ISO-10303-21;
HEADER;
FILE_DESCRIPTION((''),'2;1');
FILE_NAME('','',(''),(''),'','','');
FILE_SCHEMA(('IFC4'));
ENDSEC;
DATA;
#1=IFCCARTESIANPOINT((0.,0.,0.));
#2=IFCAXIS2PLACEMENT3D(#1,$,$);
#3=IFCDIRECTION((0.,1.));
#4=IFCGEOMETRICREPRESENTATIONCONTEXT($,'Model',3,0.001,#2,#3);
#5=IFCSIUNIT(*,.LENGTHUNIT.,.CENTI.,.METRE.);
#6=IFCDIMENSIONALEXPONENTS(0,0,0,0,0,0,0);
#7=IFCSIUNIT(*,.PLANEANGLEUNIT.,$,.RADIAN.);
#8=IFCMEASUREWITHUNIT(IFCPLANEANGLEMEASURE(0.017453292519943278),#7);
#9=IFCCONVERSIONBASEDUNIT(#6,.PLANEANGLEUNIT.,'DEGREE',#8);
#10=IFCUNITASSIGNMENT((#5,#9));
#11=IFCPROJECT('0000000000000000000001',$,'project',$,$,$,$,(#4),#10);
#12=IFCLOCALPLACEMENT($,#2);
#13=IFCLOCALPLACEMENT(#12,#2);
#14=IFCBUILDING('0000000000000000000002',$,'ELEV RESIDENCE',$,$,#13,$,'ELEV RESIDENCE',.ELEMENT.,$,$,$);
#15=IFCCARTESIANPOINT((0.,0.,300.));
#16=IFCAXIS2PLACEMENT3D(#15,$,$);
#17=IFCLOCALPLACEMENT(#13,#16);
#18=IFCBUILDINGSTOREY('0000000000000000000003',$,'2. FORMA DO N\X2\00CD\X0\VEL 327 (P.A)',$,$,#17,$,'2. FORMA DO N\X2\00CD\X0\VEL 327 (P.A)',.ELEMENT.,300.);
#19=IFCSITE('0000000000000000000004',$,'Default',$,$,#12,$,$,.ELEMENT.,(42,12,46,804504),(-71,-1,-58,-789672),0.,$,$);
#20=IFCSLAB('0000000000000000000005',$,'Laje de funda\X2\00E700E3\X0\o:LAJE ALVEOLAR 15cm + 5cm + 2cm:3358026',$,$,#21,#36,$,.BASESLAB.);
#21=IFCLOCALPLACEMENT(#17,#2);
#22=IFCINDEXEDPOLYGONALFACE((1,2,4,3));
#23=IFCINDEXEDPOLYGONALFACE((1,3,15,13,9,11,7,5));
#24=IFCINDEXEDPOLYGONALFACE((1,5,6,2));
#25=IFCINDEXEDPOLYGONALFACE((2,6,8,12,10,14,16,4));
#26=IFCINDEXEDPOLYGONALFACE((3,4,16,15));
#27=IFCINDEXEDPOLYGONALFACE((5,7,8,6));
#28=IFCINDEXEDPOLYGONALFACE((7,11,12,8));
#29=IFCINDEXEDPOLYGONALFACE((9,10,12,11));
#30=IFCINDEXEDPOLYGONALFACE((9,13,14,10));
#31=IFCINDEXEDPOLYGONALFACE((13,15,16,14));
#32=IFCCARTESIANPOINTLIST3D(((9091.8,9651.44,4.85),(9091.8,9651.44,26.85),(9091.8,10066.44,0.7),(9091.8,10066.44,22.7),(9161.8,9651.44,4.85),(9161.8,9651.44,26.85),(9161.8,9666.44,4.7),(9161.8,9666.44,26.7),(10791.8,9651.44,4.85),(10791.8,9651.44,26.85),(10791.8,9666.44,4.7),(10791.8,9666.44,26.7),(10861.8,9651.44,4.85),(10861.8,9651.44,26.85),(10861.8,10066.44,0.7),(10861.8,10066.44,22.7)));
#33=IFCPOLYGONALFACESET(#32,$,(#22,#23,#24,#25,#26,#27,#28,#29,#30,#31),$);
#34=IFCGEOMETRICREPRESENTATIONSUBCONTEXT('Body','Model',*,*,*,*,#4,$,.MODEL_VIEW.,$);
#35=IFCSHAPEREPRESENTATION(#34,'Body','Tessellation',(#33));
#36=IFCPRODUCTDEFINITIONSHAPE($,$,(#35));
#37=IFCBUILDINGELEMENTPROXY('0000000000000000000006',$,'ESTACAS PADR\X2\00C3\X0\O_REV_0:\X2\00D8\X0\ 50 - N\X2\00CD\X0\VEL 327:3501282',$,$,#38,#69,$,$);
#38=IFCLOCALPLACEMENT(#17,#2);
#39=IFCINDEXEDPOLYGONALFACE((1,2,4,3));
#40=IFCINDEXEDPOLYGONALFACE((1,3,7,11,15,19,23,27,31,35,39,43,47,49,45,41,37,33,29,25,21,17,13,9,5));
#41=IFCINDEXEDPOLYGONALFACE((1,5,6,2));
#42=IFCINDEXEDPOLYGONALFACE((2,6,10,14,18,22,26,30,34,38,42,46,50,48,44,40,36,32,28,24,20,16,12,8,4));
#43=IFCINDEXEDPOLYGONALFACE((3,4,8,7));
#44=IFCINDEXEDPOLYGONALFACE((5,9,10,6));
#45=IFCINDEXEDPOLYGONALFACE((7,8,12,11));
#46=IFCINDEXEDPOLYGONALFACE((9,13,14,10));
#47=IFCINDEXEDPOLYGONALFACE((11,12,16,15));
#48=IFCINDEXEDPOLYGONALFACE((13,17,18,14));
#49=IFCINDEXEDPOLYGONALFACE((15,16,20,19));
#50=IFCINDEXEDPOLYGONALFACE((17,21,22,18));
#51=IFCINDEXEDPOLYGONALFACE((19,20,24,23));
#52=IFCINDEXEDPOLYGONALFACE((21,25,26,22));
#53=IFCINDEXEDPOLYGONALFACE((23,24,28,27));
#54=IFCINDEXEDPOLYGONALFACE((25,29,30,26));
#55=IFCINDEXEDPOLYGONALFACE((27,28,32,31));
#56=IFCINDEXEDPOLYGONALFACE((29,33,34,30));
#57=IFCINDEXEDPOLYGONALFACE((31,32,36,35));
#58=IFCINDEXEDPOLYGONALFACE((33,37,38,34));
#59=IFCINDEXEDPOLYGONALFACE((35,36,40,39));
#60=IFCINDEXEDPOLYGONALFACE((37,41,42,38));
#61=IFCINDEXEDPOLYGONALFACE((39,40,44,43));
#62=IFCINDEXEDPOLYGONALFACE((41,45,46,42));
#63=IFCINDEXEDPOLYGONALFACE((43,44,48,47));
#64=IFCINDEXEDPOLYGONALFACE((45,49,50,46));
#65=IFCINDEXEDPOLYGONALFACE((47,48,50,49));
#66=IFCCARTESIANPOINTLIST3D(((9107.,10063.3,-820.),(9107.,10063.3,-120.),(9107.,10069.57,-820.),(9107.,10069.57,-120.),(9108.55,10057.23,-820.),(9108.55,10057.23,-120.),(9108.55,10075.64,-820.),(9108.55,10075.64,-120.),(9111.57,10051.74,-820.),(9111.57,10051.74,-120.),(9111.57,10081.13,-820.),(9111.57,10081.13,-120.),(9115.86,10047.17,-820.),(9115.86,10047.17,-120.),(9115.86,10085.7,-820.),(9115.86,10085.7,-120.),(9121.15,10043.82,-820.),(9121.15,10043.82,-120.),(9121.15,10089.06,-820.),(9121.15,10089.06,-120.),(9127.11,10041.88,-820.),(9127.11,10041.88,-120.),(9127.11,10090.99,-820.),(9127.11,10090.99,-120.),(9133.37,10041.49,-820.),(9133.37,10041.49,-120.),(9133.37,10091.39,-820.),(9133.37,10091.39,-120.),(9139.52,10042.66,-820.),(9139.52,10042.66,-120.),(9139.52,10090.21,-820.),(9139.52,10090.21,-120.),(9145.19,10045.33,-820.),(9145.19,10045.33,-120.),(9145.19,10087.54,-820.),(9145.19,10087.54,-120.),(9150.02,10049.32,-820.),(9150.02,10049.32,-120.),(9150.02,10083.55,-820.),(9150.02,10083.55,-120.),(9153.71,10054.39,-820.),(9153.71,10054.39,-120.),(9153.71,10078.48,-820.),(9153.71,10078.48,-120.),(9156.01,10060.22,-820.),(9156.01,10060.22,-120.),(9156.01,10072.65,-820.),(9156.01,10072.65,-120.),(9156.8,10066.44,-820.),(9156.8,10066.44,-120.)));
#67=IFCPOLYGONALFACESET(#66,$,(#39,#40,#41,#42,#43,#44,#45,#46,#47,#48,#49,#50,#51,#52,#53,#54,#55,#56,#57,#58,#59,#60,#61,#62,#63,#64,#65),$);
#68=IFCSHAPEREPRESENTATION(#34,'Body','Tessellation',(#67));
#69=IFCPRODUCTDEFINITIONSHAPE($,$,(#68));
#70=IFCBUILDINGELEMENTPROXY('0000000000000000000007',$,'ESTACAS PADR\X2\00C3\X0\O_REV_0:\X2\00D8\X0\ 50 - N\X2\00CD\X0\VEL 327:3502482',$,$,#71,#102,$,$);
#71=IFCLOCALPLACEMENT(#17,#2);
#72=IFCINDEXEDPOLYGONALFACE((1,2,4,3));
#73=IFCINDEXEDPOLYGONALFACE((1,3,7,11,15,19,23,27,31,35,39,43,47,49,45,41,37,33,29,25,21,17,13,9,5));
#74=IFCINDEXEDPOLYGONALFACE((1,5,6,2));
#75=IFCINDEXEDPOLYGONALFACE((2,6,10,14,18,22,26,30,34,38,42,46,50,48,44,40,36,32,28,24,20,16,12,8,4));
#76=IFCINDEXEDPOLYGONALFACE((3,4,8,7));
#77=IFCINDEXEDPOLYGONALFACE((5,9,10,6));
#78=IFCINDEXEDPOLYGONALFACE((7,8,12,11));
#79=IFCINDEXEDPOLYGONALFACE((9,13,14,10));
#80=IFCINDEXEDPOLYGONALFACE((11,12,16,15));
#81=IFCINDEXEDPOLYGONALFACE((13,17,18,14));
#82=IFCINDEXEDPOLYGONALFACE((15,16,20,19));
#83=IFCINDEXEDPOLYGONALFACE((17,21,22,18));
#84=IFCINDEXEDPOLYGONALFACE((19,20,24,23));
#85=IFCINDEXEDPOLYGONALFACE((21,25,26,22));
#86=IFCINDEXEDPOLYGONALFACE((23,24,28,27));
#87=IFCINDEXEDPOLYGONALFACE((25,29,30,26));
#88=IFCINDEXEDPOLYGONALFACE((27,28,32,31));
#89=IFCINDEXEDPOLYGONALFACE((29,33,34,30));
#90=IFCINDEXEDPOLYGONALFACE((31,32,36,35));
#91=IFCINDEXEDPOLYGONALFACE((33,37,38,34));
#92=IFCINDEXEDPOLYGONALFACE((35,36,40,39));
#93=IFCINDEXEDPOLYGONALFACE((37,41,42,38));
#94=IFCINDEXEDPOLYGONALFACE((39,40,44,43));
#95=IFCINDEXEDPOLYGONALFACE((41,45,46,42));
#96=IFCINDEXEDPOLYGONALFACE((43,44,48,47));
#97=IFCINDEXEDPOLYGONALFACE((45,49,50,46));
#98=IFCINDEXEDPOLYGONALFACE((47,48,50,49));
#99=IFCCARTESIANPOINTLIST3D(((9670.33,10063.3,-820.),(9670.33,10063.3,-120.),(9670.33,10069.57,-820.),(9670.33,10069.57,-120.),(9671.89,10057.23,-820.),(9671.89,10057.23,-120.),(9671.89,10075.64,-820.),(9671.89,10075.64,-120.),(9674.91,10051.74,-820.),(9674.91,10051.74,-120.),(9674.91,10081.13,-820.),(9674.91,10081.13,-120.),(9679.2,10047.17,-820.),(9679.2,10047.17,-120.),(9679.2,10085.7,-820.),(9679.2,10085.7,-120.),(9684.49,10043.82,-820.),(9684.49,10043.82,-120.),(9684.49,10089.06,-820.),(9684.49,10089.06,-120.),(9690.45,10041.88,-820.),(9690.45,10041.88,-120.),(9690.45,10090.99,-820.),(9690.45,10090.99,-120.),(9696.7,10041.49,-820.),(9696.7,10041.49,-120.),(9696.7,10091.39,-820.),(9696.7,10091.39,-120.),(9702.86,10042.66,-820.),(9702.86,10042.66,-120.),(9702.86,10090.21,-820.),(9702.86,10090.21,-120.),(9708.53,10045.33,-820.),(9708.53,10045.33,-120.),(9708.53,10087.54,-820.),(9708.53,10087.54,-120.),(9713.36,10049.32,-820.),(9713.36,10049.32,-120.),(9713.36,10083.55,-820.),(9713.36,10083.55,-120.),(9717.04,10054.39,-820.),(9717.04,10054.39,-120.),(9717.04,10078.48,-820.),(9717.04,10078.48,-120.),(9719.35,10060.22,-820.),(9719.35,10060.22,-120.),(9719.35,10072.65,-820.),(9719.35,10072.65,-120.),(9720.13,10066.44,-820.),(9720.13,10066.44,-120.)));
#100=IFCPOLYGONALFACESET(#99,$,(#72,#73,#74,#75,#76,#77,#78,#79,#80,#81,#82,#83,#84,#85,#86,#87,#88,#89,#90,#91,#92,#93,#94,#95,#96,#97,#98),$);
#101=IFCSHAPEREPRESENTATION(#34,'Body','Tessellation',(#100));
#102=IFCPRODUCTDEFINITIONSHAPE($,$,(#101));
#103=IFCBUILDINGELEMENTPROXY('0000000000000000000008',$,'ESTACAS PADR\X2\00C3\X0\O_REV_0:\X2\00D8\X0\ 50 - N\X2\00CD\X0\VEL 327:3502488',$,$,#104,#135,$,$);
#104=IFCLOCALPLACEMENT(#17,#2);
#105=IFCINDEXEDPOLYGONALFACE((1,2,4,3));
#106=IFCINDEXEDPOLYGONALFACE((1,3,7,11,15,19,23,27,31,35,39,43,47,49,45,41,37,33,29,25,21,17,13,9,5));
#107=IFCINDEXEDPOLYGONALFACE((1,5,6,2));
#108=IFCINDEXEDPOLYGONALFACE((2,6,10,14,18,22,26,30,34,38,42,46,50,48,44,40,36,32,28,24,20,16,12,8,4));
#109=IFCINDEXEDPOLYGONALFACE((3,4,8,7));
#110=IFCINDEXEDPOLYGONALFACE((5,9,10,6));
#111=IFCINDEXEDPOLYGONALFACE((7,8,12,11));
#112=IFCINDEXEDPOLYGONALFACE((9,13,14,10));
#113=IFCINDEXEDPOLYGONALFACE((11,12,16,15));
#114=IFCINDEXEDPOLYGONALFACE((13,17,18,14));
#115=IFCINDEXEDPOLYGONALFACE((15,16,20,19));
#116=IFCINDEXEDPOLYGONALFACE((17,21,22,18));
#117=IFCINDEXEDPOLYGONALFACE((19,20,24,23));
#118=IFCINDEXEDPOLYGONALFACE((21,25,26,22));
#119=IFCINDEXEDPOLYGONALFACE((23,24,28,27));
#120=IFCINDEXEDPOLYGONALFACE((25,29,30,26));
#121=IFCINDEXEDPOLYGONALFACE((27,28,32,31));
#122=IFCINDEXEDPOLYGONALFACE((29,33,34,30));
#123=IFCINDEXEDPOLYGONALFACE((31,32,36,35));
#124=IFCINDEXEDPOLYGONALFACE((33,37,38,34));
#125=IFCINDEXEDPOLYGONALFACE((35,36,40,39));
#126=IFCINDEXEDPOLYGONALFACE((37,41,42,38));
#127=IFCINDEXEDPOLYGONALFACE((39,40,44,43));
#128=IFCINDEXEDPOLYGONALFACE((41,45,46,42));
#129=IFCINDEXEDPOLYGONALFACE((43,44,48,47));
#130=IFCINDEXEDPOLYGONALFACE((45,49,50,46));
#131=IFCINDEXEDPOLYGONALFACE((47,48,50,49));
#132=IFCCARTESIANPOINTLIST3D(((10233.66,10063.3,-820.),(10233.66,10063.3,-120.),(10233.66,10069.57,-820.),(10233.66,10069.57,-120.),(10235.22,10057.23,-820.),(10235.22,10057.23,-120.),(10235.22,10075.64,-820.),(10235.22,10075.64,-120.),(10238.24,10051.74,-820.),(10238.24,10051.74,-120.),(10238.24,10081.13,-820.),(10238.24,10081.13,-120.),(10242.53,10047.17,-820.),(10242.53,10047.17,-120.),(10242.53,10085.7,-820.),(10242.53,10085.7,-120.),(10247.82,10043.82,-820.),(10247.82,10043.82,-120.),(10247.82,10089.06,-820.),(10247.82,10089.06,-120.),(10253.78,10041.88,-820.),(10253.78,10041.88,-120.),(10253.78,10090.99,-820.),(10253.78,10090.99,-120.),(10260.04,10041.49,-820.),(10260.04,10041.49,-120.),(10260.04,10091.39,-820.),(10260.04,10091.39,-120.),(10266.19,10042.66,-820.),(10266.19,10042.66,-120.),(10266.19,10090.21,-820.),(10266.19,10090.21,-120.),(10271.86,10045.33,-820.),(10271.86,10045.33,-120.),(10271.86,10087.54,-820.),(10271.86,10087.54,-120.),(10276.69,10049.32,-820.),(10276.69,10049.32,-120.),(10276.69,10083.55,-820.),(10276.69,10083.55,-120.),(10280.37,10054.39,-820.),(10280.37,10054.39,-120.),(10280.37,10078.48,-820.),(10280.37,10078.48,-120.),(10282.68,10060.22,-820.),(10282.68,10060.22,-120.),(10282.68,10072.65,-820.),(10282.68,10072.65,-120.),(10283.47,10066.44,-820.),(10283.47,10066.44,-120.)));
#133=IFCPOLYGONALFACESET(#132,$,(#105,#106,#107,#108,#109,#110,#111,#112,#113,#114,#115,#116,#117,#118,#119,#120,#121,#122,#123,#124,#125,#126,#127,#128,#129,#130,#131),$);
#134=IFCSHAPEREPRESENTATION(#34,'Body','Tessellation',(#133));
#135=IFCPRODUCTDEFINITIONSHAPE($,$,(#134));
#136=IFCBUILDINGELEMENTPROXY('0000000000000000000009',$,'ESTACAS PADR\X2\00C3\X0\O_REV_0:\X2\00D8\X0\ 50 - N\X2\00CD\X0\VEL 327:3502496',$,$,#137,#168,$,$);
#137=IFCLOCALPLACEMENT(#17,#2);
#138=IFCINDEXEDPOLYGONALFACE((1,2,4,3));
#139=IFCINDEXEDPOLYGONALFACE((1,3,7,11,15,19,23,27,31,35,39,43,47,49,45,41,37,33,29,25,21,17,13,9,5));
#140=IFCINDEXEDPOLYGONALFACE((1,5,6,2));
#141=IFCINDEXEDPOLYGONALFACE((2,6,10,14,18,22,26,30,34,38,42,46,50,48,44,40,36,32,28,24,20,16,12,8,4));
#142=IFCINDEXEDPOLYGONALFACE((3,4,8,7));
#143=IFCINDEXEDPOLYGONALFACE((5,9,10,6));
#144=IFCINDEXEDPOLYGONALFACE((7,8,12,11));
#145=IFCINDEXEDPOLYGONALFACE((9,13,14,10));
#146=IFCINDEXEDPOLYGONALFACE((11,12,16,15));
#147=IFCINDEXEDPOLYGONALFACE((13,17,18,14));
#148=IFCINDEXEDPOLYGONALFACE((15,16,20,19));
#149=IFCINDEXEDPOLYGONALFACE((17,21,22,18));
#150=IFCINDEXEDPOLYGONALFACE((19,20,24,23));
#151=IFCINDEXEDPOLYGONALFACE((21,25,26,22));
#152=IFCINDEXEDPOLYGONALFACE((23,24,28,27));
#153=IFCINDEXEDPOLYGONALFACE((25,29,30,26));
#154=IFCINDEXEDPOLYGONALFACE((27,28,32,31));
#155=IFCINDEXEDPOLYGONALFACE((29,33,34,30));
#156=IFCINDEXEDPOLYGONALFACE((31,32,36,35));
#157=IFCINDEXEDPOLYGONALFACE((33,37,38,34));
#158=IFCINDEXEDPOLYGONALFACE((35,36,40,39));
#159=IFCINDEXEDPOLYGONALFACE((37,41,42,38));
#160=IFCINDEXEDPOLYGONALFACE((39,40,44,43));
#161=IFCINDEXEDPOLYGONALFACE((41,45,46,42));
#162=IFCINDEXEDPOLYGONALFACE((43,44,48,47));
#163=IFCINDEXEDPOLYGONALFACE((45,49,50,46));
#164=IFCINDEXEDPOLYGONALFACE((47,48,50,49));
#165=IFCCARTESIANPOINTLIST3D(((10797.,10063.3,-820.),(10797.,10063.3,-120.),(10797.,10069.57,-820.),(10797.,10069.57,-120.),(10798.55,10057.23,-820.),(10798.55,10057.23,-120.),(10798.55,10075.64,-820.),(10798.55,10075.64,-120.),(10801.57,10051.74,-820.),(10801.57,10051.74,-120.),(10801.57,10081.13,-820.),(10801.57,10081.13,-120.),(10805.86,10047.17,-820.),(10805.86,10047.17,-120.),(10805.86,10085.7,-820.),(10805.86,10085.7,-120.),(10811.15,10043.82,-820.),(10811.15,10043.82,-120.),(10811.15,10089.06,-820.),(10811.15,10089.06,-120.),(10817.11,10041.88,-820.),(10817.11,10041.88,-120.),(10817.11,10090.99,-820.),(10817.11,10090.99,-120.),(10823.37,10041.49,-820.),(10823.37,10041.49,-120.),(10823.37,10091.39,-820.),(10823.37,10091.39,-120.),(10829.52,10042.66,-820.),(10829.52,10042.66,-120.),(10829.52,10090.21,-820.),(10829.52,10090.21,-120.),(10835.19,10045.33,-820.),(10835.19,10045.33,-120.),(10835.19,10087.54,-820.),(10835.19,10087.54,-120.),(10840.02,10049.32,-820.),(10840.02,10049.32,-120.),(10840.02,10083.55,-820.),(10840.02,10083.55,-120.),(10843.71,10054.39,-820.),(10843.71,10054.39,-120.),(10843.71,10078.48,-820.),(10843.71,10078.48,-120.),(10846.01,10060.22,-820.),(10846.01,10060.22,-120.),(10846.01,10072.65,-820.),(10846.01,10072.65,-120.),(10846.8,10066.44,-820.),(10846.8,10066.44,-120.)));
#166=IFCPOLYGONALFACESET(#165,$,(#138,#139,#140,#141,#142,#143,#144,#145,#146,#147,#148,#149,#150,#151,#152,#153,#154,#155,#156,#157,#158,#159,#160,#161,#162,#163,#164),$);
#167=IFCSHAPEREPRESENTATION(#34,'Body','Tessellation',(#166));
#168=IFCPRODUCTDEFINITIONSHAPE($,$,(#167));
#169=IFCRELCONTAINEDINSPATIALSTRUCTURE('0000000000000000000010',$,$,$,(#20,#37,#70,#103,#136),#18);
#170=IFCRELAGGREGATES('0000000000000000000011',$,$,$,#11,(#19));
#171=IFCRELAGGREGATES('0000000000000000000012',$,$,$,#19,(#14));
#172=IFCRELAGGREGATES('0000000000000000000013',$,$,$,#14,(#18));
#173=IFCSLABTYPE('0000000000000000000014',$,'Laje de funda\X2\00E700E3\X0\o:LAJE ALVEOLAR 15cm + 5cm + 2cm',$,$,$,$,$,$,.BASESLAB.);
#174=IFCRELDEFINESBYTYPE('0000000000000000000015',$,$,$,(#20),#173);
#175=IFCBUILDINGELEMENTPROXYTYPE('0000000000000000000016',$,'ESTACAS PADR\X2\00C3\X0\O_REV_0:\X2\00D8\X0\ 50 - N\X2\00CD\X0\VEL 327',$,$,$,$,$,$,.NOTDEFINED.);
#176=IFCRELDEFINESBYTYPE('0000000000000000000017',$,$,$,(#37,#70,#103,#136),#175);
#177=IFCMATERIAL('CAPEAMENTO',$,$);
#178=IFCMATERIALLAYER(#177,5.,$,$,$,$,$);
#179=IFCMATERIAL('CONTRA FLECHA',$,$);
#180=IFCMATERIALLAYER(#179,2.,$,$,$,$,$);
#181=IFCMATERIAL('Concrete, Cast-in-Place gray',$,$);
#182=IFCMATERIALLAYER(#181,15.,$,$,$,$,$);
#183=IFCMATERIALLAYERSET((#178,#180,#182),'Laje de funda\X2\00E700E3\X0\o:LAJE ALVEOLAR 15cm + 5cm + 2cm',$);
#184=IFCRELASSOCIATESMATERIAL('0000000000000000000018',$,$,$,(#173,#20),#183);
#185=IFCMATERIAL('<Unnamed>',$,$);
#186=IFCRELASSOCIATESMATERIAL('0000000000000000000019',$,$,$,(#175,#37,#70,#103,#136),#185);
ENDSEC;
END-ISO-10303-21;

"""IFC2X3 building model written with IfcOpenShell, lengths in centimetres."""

from ifc_helpers import new_model, entity, si_unit, converted_unit, direction, frame, frame_2d, origin, place, context, subcontext, project, spatial, polyline, circle, outline, extrude, clip, halfspace, source, transform, mapped, material, layer, layer_set, layer_usage, type_object, type_shapes, element, save


model = new_model("IFC2X3")

# Units and contexts
model_context = context("Model", 3, precision=0.001, world=origin(), true_north=direction((0.0, 1.0)))
body_context = subcontext(model_context, "Body", "Model", "MODEL_VIEW")
ifc_project = project(units=[si_unit("LENGTHUNIT", "METRE", prefix="CENTI"), converted_unit("PLANEANGLEUNIT", "DEGREE", entity("IfcPlaneAngleMeasure", 0.017453292519943278), si_unit("PLANEANGLEUNIT", "RADIAN"), dimensions=[0, 0, 0, 0, 0, 0, 0])], contexts=[model_context])

# Site, building, storey
site_placement = place(None, origin())
site = spatial("IfcSite", under=ifc_project, at=site_placement, Name="Default", CompositionType="ELEMENT", RefLatitude=(42, 12, 46, 804504), RefLongitude=(-71, -1, -58, -789672), RefElevation=0.0)
building_placement = place(site_placement, origin())
building = spatial("IfcBuilding", under=site, at=building_placement, Name="ELEV RESIDENCE", LongName="ELEV RESIDENCE", CompositionType="ELEMENT")
storey_placement = place(building_placement, frame((0.0, 0.0, 300.0)))
storey = spatial("IfcBuildingStorey", under=building, at=storey_placement, Name="2. FORMA DO NÍVEL 327 (P.A)", LongName="2. FORMA DO NÍVEL 327 (P.A)", CompositionType="ELEMENT", Elevation=300.0)

# Shared definitions
ifc_material_1 = material(Name="CAPEAMENTO")
ifc_material_2 = material(Name="CONTRA FLECHA")
ifc_material_3 = material(Name="Concrete, Cast-in-Place gray")

# Slab
ifc_layer_1 = layer(ifc_material_1, 5.0)
ifc_layer_2 = layer(ifc_material_2, 2.0)
ifc_layer_3 = layer(ifc_material_3, 15.0)
ifc_layer_set_1 = layer_set([ifc_layer_1, ifc_layer_2, ifc_layer_3], Name="Laje de fundação:LAJE ALVEOLAR 15cm + 5cm + 2cm")
ifc_layer_usage_1 = layer_usage(ifc_layer_set_1, "AXIS3", "POSITIVE", 0.0)
slab_type_1 = type_object("IfcSlabType", Name="Laje de fundação:LAJE ALVEOLAR 15cm + 5cm + 2cm", PredefinedType="BASESLAB", material=ifc_layer_set_1)
slab_1_placement = place(storey_placement, origin())
element("IfcSlab", 1, at=slab_1_placement, inside=storey, type_object=slab_type_1, material=ifc_layer_usage_1, Name="Laje de fundação:LAJE ALVEOLAR 15cm + 5cm + 2cm:3358026", PredefinedType="BASESLAB", context=body_context, shape_type="Clipping", body=[
    clip(clip(extrude(outline(polyline([(-107.51, -885.0), (307.52, -885.0), (307.52, 885.0), (-107.51, 885.0), (-107.51, 815.0), (-92.5, 815.0), (-92.5, -815.0), (-107.51, -815.0), (-107.51, -885.0)])), frame((9976.8, 9758.94, 25.77), z_axis=(0.0, -0.01, -0.99995), x_axis=(0.0, 0.99995, -0.01)), (0.01, 0.0, 0.99995), 22.0), halfspace(frame((9976.8, 9666.44, 4.7), z_axis=(0.0, -0.01, -0.99995), x_axis=(0.0, 0.99995, -0.01)), False)), halfspace(frame((9976.8, 9666.44, 26.7), z_axis=(0.0, 0.01, 0.99995), x_axis=(0.0, -0.99995, 0.01)), False)),
])

# Building element proxies
ifc_material_4 = material(Name="<Unnamed>")
building_element_proxy_type_1 = type_object("IfcBuildingElementProxyType", Name="ESTACAS PADRÃO_REV_0:Ø 50 - NÍVEL 327", PredefinedType="NOTDEFINED", material=ifc_material_4)
shared_shape_1 = source(origin(), body_context, "Body", "SweptSolid", [
    extrude(circle(Radius=25.0, at=frame_2d((0.0, 0.0), x_axis=(1.0, 0.0))), frame((0.0, 0.0, -820.0)), (0.0, 0.0, 1.0), 700.0),
])
type_shapes(building_element_proxy_type_1, [shared_shape_1])
for number, where, name in (
    (2, (9131.8, 10066.44, 0.0), "ESTACAS PADRÃO_REV_0:Ø 50 - NÍVEL 327:3501282"),
    (3, (9695.13, 10066.44, 0.0), "ESTACAS PADRÃO_REV_0:Ø 50 - NÍVEL 327:3502482"),
    (4, (10258.47, 10066.44, 0.0), "ESTACAS PADRÃO_REV_0:Ø 50 - NÍVEL 327:3502488"),
    (5, (10821.8, 10066.44, 0.0), "ESTACAS PADRÃO_REV_0:Ø 50 - NÍVEL 327:3502496"),
):
    element("IfcBuildingElementProxy", number, at=place(storey_placement, frame(where)), inside=storey, type_object=building_element_proxy_type_1, material=ifc_material_4, Name=name, context=body_context, shape_type="MappedRepresentation", body=[
        mapped(shared_shape_1, transform((0.0, 0.0, 0.0), scale=1.0)),
    ])

save(model, "model.ifc")
